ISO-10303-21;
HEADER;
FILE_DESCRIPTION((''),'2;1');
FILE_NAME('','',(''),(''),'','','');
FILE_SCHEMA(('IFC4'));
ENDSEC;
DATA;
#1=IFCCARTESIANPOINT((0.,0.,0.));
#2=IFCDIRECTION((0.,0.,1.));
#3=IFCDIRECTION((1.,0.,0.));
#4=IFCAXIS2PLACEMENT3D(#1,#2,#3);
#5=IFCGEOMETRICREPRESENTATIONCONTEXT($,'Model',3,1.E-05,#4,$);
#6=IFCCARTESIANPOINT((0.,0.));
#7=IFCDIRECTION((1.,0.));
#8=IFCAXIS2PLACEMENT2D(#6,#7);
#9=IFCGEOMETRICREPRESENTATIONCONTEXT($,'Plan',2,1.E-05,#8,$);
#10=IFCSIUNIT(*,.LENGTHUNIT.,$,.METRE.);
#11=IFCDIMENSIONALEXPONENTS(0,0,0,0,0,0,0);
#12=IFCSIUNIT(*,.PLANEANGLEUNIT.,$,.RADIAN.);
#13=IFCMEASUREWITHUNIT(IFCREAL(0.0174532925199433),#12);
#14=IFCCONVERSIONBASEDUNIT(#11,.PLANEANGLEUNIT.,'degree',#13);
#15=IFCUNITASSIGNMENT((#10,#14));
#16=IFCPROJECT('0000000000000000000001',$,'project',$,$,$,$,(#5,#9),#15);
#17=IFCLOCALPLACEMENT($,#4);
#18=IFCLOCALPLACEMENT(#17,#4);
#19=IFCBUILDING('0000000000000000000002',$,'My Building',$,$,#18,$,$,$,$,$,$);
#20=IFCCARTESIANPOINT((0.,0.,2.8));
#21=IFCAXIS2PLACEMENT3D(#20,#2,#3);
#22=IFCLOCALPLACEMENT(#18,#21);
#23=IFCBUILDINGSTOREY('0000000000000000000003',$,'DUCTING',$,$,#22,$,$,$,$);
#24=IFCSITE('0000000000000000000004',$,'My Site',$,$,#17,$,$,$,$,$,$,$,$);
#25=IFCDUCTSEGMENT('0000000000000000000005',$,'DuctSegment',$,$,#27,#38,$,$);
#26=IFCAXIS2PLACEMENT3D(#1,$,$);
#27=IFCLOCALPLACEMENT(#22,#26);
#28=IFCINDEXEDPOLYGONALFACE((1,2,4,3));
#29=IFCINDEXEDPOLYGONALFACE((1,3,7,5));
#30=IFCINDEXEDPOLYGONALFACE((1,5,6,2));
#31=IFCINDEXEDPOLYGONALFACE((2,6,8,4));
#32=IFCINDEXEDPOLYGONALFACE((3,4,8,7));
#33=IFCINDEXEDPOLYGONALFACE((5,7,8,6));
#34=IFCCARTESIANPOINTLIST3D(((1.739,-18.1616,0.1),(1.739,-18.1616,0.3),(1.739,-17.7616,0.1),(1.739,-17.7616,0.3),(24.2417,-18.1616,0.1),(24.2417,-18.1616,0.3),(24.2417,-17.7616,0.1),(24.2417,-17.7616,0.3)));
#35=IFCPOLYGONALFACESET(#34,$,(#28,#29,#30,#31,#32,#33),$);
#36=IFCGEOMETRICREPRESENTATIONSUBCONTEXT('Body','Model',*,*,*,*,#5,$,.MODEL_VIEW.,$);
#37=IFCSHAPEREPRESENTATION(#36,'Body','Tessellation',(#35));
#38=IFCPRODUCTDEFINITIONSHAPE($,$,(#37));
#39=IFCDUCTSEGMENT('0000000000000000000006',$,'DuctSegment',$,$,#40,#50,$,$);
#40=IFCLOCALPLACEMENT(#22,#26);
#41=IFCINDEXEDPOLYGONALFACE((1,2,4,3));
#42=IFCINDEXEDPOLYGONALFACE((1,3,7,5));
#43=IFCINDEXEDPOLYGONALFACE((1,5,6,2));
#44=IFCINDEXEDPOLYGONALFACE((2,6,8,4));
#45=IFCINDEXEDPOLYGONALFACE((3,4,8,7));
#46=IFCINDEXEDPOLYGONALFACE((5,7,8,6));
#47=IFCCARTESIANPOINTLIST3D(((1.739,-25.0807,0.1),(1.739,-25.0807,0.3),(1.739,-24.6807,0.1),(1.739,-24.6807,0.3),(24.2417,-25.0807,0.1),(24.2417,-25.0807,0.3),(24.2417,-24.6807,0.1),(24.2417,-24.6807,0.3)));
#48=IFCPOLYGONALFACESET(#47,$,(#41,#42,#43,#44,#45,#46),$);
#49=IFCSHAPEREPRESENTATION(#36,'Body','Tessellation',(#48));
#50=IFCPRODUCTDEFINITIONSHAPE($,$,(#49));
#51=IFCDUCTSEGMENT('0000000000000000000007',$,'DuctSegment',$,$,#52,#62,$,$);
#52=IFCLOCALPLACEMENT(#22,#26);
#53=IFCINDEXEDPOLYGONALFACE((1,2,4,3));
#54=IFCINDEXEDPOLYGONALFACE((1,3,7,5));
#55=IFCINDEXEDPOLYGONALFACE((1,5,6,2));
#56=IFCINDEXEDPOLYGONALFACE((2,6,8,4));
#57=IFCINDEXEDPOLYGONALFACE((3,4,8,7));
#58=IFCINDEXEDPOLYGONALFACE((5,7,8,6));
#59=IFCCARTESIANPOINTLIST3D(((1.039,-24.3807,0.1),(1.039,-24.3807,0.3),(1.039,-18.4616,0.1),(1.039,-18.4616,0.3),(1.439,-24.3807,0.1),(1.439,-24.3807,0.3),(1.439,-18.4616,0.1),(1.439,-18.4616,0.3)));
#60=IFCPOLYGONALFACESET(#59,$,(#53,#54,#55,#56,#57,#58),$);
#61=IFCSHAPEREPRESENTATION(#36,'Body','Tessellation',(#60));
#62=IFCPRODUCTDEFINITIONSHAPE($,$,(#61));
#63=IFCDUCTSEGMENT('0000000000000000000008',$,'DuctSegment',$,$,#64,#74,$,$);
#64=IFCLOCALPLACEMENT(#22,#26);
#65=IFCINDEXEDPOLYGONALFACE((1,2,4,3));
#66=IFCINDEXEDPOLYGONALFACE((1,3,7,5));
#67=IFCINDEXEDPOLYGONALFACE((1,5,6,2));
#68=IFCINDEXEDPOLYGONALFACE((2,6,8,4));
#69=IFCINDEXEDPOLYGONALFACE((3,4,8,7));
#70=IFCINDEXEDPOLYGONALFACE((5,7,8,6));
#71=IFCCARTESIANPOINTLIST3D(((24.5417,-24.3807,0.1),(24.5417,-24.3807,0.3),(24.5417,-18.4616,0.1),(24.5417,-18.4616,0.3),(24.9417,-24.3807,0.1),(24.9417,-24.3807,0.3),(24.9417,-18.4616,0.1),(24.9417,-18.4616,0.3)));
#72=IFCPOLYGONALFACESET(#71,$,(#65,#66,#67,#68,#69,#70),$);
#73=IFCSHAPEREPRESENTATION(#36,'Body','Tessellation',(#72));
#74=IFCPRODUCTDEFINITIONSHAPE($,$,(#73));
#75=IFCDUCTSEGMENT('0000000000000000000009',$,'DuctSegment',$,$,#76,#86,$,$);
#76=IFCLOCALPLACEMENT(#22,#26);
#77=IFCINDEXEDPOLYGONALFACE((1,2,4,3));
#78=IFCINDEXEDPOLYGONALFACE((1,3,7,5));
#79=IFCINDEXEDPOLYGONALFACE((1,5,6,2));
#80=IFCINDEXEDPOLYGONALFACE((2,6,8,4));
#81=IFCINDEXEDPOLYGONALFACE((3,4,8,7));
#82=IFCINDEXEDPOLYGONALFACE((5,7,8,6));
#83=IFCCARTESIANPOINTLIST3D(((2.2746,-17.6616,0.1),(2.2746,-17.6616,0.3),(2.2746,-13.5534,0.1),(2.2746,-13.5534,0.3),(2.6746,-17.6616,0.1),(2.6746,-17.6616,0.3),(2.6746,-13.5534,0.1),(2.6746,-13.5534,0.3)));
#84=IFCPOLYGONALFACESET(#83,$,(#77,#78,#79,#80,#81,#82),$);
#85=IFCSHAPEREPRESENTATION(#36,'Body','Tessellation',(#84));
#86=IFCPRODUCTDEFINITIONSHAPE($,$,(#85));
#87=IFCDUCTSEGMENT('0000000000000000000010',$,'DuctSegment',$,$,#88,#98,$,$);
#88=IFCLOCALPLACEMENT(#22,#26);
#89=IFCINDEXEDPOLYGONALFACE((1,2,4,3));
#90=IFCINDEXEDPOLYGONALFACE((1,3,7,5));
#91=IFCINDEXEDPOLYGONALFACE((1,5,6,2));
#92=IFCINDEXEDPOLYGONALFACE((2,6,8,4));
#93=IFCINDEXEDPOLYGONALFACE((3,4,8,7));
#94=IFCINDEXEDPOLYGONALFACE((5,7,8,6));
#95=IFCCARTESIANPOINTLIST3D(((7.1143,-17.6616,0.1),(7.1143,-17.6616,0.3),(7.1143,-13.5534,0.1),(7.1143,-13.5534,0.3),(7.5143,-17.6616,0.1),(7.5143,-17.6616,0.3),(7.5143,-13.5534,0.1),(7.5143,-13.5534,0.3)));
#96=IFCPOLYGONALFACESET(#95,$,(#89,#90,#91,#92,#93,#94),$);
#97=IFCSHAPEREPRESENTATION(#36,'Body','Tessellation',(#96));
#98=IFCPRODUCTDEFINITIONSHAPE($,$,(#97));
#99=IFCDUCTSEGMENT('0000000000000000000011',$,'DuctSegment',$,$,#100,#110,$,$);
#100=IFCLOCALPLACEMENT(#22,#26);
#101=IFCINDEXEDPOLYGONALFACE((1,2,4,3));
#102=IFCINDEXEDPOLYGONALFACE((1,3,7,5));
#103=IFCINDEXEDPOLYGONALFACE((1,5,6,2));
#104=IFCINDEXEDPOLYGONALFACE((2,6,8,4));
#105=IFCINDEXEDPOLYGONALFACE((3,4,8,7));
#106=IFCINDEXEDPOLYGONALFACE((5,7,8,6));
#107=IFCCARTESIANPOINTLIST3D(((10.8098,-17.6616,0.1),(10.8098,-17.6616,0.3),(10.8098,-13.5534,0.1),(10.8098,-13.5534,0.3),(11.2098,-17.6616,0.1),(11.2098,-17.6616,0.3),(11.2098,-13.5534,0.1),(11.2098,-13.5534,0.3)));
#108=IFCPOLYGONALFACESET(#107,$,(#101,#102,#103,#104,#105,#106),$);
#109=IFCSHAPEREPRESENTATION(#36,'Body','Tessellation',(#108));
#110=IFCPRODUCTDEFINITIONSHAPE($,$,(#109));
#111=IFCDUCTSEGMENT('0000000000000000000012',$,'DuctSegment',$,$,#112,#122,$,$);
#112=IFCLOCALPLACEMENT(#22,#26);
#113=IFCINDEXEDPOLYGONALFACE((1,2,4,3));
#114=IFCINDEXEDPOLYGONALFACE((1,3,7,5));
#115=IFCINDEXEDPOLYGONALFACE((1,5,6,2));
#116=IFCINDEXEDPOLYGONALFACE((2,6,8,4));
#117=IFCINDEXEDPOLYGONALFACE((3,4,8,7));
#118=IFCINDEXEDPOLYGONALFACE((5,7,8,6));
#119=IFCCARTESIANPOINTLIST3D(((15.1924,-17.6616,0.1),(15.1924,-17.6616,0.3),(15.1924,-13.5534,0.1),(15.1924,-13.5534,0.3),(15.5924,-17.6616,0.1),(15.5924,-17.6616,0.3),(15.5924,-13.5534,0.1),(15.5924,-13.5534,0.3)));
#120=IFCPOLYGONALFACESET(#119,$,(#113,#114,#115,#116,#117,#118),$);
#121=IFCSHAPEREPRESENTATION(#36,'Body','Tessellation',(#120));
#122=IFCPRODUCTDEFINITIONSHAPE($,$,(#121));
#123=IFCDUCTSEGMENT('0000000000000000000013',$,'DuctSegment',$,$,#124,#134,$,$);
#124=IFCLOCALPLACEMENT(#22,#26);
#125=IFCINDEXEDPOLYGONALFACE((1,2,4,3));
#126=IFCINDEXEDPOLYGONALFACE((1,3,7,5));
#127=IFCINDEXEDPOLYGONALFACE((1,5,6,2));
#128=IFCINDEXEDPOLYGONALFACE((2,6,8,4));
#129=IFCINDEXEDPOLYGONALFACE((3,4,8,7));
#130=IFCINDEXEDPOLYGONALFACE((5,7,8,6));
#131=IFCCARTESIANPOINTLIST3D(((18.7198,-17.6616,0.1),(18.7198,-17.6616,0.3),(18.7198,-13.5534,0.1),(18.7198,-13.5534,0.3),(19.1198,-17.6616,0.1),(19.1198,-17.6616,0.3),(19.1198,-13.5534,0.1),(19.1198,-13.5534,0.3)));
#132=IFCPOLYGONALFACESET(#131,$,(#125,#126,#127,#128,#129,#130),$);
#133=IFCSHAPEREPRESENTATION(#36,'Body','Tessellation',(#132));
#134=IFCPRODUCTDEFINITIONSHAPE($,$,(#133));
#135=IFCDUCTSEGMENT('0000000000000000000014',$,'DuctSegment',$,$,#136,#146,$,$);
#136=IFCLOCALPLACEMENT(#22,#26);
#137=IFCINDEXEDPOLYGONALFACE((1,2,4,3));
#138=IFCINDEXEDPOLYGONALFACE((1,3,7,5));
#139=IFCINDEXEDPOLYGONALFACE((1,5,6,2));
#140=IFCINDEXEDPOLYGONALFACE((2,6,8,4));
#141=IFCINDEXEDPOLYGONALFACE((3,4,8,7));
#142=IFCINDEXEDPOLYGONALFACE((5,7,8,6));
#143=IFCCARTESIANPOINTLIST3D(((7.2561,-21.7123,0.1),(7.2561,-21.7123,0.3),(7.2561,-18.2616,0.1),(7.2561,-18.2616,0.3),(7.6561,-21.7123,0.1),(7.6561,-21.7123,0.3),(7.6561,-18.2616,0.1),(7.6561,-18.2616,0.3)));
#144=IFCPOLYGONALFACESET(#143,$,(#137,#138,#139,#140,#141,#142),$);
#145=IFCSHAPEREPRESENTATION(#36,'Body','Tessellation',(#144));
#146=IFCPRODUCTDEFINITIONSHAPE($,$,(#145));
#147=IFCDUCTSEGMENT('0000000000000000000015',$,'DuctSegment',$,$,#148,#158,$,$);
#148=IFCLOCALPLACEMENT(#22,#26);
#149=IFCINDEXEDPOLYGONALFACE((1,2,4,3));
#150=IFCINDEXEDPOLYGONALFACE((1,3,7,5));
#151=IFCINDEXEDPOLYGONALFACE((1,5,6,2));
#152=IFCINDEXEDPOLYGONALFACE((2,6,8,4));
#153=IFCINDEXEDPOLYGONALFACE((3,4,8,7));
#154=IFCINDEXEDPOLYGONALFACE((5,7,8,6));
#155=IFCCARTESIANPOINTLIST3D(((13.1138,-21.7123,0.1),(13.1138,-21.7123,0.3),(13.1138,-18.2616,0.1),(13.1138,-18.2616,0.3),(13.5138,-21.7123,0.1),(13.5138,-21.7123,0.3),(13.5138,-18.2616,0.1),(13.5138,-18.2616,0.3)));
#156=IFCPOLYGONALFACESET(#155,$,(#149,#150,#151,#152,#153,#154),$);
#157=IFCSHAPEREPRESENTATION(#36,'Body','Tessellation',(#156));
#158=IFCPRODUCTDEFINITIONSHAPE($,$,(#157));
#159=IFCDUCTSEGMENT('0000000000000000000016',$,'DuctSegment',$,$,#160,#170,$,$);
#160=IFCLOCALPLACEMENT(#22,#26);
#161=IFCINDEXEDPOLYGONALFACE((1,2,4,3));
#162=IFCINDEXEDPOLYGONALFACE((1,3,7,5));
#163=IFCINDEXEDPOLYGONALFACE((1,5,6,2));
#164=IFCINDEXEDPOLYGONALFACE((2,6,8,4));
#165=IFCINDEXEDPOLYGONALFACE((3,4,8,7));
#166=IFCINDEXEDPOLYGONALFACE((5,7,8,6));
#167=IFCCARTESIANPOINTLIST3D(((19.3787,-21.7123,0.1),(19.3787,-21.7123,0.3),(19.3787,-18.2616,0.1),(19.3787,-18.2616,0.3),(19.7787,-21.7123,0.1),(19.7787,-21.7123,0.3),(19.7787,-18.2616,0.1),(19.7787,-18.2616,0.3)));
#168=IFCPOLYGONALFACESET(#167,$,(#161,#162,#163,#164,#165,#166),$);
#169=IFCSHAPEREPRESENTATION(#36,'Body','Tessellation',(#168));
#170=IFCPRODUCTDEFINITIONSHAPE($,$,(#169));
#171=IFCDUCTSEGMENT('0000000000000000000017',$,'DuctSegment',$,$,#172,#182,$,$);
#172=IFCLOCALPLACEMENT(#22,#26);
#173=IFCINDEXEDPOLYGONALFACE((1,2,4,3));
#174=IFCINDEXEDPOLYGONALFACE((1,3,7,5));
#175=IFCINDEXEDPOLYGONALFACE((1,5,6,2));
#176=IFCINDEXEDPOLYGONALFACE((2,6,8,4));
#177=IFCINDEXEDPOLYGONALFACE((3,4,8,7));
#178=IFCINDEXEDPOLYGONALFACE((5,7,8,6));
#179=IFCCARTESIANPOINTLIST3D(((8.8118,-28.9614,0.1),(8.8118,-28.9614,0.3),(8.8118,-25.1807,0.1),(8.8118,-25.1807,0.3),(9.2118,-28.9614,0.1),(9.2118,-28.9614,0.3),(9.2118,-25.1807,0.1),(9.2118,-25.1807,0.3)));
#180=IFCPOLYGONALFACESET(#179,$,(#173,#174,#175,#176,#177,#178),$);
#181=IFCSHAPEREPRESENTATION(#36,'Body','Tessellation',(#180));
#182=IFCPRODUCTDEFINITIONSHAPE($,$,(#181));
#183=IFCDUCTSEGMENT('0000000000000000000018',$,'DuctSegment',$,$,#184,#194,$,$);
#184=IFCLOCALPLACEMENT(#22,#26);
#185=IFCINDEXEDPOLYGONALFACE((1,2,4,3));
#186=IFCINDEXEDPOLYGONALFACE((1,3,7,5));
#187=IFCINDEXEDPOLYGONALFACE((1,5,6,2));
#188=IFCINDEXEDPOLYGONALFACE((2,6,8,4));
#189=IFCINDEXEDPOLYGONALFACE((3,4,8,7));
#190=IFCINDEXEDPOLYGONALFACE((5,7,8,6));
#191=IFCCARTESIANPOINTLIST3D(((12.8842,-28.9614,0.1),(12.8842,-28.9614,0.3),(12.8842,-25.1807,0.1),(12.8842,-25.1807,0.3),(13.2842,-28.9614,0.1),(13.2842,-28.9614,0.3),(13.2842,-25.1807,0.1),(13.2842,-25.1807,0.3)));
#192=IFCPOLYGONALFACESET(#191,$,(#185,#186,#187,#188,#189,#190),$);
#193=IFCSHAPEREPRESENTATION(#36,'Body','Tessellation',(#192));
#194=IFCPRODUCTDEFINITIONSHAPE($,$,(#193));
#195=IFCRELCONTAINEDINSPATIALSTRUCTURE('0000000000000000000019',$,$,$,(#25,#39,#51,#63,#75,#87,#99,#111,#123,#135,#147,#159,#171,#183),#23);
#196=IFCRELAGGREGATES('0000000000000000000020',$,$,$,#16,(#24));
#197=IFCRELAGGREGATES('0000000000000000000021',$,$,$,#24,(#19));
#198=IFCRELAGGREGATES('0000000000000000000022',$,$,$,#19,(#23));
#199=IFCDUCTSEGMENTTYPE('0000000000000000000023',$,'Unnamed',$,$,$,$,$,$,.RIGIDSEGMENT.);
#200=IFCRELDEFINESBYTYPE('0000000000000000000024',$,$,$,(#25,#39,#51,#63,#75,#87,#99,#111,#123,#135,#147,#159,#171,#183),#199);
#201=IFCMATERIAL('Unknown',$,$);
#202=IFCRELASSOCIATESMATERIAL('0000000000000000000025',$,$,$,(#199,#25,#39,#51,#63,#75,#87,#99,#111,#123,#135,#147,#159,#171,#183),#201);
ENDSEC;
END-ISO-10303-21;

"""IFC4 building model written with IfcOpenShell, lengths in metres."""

from ifc_helpers import new_model, entity, si_unit, converted_unit, frame, origin_with_axes, origin_2d_with_axis, place, context, subcontext, project, spatial, rectangle, extrude, material, material_profile, profile_set, profile_usage, type_object, element, save


model = new_model("IFC4")

# Units and contexts
model_context = context("Model", 3, precision=1e-05, world=origin_with_axes())
plan_context = context("Plan", 2, precision=1e-05, world=origin_2d_with_axis())
body_context = subcontext(model_context, "Body", "Model", "MODEL_VIEW")
ifc_project = project(units=[si_unit("LENGTHUNIT", "METRE"), converted_unit("PLANEANGLEUNIT", "degree", entity("IfcReal", 0.0174532925199433), si_unit("PLANEANGLEUNIT", "RADIAN"), dimensions=[0, 0, 0, 0, 0, 0, 0])], contexts=[model_context, plan_context])

# Site, building, storey
site_placement = place(None, origin_with_axes())
site = spatial("IfcSite", under=ifc_project, at=site_placement, Name="My Site")
building_placement = place(site_placement, origin_with_axes())
building = spatial("IfcBuilding", under=site, at=building_placement, Name="My Building")
storey_placement = place(building_placement, frame((0.0, 0.0, 2.8), z_axis=(0.0, 0.0, 1.0), x_axis=(1.0, 0.0, 0.0)))
storey = spatial("IfcBuildingStorey", under=building, at=storey_placement, Name="DUCTING")

# Duct segments
ifc_material = material(Name="Unknown")
ifc_material_profile = material_profile(ifc_material, rectangle(XDim=0.4, YDim=0.2))
ifc_profile_set = profile_set([ifc_material_profile])
ifc_profile_usage_1 = profile_usage(ifc_profile_set, cardinal=5)
duct_segment_type = type_object("IfcDuctSegmentType", Name="Unnamed", PredefinedType="RIGIDSEGMENT", material=ifc_profile_set)
duct_segment_1_placement = place(storey_placement, frame((24.2417, -17.9616, 0.2), z_axis=(-1.0, 0.0, 0.0), x_axis=(0.0, -1.0, 0.0)))
element("IfcDuctSegment", 1, at=duct_segment_1_placement, inside=storey, type_object=duct_segment_type, material=ifc_profile_usage_1, Name="DuctSegment", context=body_context, shape_type="SweptSolid", body=[
    extrude(rectangle(XDim=0.4, YDim=0.2), origin_with_axes(), (0.0, 0.0, 1.0), 22.5027),
])
ifc_profile_usage_2 = profile_usage(ifc_profile_set, cardinal=5)
duct_segment_2_placement = place(storey_placement, frame((24.2417, -24.8807, 0.2), z_axis=(-1.0, 0.0, 0.0), x_axis=(0.0, -1.0, 0.0)))
element("IfcDuctSegment", 2, at=duct_segment_2_placement, inside=storey, type_object=duct_segment_type, material=ifc_profile_usage_2, Name="DuctSegment", context=body_context, shape_type="SweptSolid", body=[
    extrude(rectangle(XDim=0.4, YDim=0.2), origin_with_axes(), (0.0, 0.0, 1.0), 22.5027),
])
ifc_profile_usage_3 = profile_usage(ifc_profile_set, cardinal=5)
duct_segment_3_placement = place(storey_placement, frame((1.239, -18.4616, 0.2), z_axis=(0.0, -1.0, 0.0), x_axis=(1.0, 0.0, 0.0)))
element("IfcDuctSegment", 3, at=duct_segment_3_placement, inside=storey, type_object=duct_segment_type, material=ifc_profile_usage_3, Name="DuctSegment", context=body_context, shape_type="SweptSolid", body=[
    extrude(rectangle(XDim=0.4, YDim=0.2), origin_with_axes(), (0.0, 0.0, 1.0), 5.919),
])
ifc_profile_usage_4 = profile_usage(ifc_profile_set, cardinal=5)
duct_segment_4_placement = place(storey_placement, frame((24.7417, -18.4616, 0.2), z_axis=(0.0, -1.0, 0.0), x_axis=(1.0, 0.0, 0.0)))
element("IfcDuctSegment", 4, at=duct_segment_4_placement, inside=storey, type_object=duct_segment_type, material=ifc_profile_usage_4, Name="DuctSegment", context=body_context, shape_type="SweptSolid", body=[
    extrude(rectangle(XDim=0.4, YDim=0.2), origin_with_axes(), (0.0, 0.0, 1.0), 5.919),
])
ifc_profile_usage_5 = profile_usage(ifc_profile_set, cardinal=5)
duct_segment_5_placement = place(storey_placement, frame((2.4746, -17.6616, 0.2), z_axis=(0.0, 1.0, 0.0), x_axis=(-1.0, 0.0, 0.0)))
element("IfcDuctSegment", 5, at=duct_segment_5_placement, inside=storey, type_object=duct_segment_type, material=ifc_profile_usage_5, Name="DuctSegment", context=body_context, shape_type="SweptSolid", body=[
    extrude(rectangle(XDim=0.4, YDim=0.2), origin_with_axes(), (0.0, 0.0, 1.0), 4.1082),
])
ifc_profile_usage_6 = profile_usage(ifc_profile_set, cardinal=5)
duct_segment_6_placement = place(storey_placement, frame((7.3143, -17.6616, 0.2), z_axis=(0.0, 1.0, 0.0), x_axis=(-1.0, 0.0, 0.0)))
element("IfcDuctSegment", 6, at=duct_segment_6_placement, inside=storey, type_object=duct_segment_type, material=ifc_profile_usage_6, Name="DuctSegment", context=body_context, shape_type="SweptSolid", body=[
    extrude(rectangle(XDim=0.4, YDim=0.2), origin_with_axes(), (0.0, 0.0, 1.0), 4.1082),
])
ifc_profile_usage_7 = profile_usage(ifc_profile_set, cardinal=5)
duct_segment_7_placement = place(storey_placement, frame((11.0098, -17.6616, 0.2), z_axis=(0.0, 1.0, 0.0), x_axis=(-1.0, 0.0, 0.0)))
element("IfcDuctSegment", 7, at=duct_segment_7_placement, inside=storey, type_object=duct_segment_type, material=ifc_profile_usage_7, Name="DuctSegment", context=body_context, shape_type="SweptSolid", body=[
    extrude(rectangle(XDim=0.4, YDim=0.2), origin_with_axes(), (0.0, 0.0, 1.0), 4.1082),
])
ifc_profile_usage_8 = profile_usage(ifc_profile_set, cardinal=5)
duct_segment_8_placement = place(storey_placement, frame((15.3924, -17.6616, 0.2), z_axis=(0.0, 1.0, 0.0), x_axis=(-1.0, 0.0, 0.0)))
element("IfcDuctSegment", 8, at=duct_segment_8_placement, inside=storey, type_object=duct_segment_type, material=ifc_profile_usage_8, Name="DuctSegment", context=body_context, shape_type="SweptSolid", body=[
    extrude(rectangle(XDim=0.4, YDim=0.2), origin_with_axes(), (0.0, 0.0, 1.0), 4.1082),
])
ifc_profile_usage_9 = profile_usage(ifc_profile_set, cardinal=5)
duct_segment_9_placement = place(storey_placement, frame((18.9198, -17.6616, 0.2), z_axis=(0.0, 1.0, 0.0), x_axis=(-1.0, 0.0, 0.0)))
element("IfcDuctSegment", 9, at=duct_segment_9_placement, inside=storey, type_object=duct_segment_type, material=ifc_profile_usage_9, Name="DuctSegment", context=body_context, shape_type="SweptSolid", body=[
    extrude(rectangle(XDim=0.4, YDim=0.2), origin_with_axes(), (0.0, 0.0, 1.0), 4.1082),
])
ifc_profile_usage_10 = profile_usage(ifc_profile_set, cardinal=5)
duct_segment_10_placement = place(storey_placement, frame((7.4561, -18.2616, 0.2), z_axis=(0.0, -1.0, 0.0), x_axis=(1.0, 0.0, 0.0)))
element("IfcDuctSegment", 10, at=duct_segment_10_placement, inside=storey, type_object=duct_segment_type, material=ifc_profile_usage_10, Name="DuctSegment", context=body_context, shape_type="SweptSolid", body=[
    extrude(rectangle(XDim=0.4, YDim=0.2), origin_with_axes(), (0.0, 0.0, 1.0), 3.4506),
])
ifc_profile_usage_11 = profile_usage(ifc_profile_set, cardinal=5)
duct_segment_11_placement = place(storey_placement, frame((13.3138, -18.2616, 0.2), z_axis=(0.0, -1.0, 0.0), x_axis=(1.0, 0.0, 0.0)))
element("IfcDuctSegment", 11, at=duct_segment_11_placement, inside=storey, type_object=duct_segment_type, material=ifc_profile_usage_11, Name="DuctSegment", context=body_context, shape_type="SweptSolid", body=[
    extrude(rectangle(XDim=0.4, YDim=0.2), origin_with_axes(), (0.0, 0.0, 1.0), 3.4506),
])
ifc_profile_usage_12 = profile_usage(ifc_profile_set, cardinal=5)
duct_segment_12_placement = place(storey_placement, frame((19.5787, -18.2616, 0.2), z_axis=(0.0, -1.0, 0.0), x_axis=(1.0, 0.0, 0.0)))
element("IfcDuctSegment", 12, at=duct_segment_12_placement, inside=storey, type_object=duct_segment_type, material=ifc_profile_usage_12, Name="DuctSegment", context=body_context, shape_type="SweptSolid", body=[
    extrude(rectangle(XDim=0.4, YDim=0.2), origin_with_axes(), (0.0, 0.0, 1.0), 3.4506),
])
ifc_profile_usage_13 = profile_usage(ifc_profile_set, cardinal=5)
duct_segment_13_placement = place(storey_placement, frame((9.0118, -25.1807, 0.2), z_axis=(0.0, -1.0, 0.0), x_axis=(1.0, 0.0, 0.0)))
element("IfcDuctSegment", 13, at=duct_segment_13_placement, inside=storey, type_object=duct_segment_type, material=ifc_profile_usage_13, Name="DuctSegment", context=body_context, shape_type="SweptSolid", body=[
    extrude(rectangle(XDim=0.4, YDim=0.2), origin_with_axes(), (0.0, 0.0, 1.0), 3.7807),
])
ifc_profile_usage_14 = profile_usage(ifc_profile_set, cardinal=5)
duct_segment_14_placement = place(storey_placement, frame((13.0842, -25.1807, 0.2), z_axis=(0.0, -1.0, 0.0), x_axis=(1.0, 0.0, 0.0)))
element("IfcDuctSegment", 14, at=duct_segment_14_placement, inside=storey, type_object=duct_segment_type, material=ifc_profile_usage_14, Name="DuctSegment", context=body_context, shape_type="SweptSolid", body=[
    extrude(rectangle(XDim=0.4, YDim=0.2), origin_with_axes(), (0.0, 0.0, 1.0), 3.7807),
])

save(model, "model.ifc")
